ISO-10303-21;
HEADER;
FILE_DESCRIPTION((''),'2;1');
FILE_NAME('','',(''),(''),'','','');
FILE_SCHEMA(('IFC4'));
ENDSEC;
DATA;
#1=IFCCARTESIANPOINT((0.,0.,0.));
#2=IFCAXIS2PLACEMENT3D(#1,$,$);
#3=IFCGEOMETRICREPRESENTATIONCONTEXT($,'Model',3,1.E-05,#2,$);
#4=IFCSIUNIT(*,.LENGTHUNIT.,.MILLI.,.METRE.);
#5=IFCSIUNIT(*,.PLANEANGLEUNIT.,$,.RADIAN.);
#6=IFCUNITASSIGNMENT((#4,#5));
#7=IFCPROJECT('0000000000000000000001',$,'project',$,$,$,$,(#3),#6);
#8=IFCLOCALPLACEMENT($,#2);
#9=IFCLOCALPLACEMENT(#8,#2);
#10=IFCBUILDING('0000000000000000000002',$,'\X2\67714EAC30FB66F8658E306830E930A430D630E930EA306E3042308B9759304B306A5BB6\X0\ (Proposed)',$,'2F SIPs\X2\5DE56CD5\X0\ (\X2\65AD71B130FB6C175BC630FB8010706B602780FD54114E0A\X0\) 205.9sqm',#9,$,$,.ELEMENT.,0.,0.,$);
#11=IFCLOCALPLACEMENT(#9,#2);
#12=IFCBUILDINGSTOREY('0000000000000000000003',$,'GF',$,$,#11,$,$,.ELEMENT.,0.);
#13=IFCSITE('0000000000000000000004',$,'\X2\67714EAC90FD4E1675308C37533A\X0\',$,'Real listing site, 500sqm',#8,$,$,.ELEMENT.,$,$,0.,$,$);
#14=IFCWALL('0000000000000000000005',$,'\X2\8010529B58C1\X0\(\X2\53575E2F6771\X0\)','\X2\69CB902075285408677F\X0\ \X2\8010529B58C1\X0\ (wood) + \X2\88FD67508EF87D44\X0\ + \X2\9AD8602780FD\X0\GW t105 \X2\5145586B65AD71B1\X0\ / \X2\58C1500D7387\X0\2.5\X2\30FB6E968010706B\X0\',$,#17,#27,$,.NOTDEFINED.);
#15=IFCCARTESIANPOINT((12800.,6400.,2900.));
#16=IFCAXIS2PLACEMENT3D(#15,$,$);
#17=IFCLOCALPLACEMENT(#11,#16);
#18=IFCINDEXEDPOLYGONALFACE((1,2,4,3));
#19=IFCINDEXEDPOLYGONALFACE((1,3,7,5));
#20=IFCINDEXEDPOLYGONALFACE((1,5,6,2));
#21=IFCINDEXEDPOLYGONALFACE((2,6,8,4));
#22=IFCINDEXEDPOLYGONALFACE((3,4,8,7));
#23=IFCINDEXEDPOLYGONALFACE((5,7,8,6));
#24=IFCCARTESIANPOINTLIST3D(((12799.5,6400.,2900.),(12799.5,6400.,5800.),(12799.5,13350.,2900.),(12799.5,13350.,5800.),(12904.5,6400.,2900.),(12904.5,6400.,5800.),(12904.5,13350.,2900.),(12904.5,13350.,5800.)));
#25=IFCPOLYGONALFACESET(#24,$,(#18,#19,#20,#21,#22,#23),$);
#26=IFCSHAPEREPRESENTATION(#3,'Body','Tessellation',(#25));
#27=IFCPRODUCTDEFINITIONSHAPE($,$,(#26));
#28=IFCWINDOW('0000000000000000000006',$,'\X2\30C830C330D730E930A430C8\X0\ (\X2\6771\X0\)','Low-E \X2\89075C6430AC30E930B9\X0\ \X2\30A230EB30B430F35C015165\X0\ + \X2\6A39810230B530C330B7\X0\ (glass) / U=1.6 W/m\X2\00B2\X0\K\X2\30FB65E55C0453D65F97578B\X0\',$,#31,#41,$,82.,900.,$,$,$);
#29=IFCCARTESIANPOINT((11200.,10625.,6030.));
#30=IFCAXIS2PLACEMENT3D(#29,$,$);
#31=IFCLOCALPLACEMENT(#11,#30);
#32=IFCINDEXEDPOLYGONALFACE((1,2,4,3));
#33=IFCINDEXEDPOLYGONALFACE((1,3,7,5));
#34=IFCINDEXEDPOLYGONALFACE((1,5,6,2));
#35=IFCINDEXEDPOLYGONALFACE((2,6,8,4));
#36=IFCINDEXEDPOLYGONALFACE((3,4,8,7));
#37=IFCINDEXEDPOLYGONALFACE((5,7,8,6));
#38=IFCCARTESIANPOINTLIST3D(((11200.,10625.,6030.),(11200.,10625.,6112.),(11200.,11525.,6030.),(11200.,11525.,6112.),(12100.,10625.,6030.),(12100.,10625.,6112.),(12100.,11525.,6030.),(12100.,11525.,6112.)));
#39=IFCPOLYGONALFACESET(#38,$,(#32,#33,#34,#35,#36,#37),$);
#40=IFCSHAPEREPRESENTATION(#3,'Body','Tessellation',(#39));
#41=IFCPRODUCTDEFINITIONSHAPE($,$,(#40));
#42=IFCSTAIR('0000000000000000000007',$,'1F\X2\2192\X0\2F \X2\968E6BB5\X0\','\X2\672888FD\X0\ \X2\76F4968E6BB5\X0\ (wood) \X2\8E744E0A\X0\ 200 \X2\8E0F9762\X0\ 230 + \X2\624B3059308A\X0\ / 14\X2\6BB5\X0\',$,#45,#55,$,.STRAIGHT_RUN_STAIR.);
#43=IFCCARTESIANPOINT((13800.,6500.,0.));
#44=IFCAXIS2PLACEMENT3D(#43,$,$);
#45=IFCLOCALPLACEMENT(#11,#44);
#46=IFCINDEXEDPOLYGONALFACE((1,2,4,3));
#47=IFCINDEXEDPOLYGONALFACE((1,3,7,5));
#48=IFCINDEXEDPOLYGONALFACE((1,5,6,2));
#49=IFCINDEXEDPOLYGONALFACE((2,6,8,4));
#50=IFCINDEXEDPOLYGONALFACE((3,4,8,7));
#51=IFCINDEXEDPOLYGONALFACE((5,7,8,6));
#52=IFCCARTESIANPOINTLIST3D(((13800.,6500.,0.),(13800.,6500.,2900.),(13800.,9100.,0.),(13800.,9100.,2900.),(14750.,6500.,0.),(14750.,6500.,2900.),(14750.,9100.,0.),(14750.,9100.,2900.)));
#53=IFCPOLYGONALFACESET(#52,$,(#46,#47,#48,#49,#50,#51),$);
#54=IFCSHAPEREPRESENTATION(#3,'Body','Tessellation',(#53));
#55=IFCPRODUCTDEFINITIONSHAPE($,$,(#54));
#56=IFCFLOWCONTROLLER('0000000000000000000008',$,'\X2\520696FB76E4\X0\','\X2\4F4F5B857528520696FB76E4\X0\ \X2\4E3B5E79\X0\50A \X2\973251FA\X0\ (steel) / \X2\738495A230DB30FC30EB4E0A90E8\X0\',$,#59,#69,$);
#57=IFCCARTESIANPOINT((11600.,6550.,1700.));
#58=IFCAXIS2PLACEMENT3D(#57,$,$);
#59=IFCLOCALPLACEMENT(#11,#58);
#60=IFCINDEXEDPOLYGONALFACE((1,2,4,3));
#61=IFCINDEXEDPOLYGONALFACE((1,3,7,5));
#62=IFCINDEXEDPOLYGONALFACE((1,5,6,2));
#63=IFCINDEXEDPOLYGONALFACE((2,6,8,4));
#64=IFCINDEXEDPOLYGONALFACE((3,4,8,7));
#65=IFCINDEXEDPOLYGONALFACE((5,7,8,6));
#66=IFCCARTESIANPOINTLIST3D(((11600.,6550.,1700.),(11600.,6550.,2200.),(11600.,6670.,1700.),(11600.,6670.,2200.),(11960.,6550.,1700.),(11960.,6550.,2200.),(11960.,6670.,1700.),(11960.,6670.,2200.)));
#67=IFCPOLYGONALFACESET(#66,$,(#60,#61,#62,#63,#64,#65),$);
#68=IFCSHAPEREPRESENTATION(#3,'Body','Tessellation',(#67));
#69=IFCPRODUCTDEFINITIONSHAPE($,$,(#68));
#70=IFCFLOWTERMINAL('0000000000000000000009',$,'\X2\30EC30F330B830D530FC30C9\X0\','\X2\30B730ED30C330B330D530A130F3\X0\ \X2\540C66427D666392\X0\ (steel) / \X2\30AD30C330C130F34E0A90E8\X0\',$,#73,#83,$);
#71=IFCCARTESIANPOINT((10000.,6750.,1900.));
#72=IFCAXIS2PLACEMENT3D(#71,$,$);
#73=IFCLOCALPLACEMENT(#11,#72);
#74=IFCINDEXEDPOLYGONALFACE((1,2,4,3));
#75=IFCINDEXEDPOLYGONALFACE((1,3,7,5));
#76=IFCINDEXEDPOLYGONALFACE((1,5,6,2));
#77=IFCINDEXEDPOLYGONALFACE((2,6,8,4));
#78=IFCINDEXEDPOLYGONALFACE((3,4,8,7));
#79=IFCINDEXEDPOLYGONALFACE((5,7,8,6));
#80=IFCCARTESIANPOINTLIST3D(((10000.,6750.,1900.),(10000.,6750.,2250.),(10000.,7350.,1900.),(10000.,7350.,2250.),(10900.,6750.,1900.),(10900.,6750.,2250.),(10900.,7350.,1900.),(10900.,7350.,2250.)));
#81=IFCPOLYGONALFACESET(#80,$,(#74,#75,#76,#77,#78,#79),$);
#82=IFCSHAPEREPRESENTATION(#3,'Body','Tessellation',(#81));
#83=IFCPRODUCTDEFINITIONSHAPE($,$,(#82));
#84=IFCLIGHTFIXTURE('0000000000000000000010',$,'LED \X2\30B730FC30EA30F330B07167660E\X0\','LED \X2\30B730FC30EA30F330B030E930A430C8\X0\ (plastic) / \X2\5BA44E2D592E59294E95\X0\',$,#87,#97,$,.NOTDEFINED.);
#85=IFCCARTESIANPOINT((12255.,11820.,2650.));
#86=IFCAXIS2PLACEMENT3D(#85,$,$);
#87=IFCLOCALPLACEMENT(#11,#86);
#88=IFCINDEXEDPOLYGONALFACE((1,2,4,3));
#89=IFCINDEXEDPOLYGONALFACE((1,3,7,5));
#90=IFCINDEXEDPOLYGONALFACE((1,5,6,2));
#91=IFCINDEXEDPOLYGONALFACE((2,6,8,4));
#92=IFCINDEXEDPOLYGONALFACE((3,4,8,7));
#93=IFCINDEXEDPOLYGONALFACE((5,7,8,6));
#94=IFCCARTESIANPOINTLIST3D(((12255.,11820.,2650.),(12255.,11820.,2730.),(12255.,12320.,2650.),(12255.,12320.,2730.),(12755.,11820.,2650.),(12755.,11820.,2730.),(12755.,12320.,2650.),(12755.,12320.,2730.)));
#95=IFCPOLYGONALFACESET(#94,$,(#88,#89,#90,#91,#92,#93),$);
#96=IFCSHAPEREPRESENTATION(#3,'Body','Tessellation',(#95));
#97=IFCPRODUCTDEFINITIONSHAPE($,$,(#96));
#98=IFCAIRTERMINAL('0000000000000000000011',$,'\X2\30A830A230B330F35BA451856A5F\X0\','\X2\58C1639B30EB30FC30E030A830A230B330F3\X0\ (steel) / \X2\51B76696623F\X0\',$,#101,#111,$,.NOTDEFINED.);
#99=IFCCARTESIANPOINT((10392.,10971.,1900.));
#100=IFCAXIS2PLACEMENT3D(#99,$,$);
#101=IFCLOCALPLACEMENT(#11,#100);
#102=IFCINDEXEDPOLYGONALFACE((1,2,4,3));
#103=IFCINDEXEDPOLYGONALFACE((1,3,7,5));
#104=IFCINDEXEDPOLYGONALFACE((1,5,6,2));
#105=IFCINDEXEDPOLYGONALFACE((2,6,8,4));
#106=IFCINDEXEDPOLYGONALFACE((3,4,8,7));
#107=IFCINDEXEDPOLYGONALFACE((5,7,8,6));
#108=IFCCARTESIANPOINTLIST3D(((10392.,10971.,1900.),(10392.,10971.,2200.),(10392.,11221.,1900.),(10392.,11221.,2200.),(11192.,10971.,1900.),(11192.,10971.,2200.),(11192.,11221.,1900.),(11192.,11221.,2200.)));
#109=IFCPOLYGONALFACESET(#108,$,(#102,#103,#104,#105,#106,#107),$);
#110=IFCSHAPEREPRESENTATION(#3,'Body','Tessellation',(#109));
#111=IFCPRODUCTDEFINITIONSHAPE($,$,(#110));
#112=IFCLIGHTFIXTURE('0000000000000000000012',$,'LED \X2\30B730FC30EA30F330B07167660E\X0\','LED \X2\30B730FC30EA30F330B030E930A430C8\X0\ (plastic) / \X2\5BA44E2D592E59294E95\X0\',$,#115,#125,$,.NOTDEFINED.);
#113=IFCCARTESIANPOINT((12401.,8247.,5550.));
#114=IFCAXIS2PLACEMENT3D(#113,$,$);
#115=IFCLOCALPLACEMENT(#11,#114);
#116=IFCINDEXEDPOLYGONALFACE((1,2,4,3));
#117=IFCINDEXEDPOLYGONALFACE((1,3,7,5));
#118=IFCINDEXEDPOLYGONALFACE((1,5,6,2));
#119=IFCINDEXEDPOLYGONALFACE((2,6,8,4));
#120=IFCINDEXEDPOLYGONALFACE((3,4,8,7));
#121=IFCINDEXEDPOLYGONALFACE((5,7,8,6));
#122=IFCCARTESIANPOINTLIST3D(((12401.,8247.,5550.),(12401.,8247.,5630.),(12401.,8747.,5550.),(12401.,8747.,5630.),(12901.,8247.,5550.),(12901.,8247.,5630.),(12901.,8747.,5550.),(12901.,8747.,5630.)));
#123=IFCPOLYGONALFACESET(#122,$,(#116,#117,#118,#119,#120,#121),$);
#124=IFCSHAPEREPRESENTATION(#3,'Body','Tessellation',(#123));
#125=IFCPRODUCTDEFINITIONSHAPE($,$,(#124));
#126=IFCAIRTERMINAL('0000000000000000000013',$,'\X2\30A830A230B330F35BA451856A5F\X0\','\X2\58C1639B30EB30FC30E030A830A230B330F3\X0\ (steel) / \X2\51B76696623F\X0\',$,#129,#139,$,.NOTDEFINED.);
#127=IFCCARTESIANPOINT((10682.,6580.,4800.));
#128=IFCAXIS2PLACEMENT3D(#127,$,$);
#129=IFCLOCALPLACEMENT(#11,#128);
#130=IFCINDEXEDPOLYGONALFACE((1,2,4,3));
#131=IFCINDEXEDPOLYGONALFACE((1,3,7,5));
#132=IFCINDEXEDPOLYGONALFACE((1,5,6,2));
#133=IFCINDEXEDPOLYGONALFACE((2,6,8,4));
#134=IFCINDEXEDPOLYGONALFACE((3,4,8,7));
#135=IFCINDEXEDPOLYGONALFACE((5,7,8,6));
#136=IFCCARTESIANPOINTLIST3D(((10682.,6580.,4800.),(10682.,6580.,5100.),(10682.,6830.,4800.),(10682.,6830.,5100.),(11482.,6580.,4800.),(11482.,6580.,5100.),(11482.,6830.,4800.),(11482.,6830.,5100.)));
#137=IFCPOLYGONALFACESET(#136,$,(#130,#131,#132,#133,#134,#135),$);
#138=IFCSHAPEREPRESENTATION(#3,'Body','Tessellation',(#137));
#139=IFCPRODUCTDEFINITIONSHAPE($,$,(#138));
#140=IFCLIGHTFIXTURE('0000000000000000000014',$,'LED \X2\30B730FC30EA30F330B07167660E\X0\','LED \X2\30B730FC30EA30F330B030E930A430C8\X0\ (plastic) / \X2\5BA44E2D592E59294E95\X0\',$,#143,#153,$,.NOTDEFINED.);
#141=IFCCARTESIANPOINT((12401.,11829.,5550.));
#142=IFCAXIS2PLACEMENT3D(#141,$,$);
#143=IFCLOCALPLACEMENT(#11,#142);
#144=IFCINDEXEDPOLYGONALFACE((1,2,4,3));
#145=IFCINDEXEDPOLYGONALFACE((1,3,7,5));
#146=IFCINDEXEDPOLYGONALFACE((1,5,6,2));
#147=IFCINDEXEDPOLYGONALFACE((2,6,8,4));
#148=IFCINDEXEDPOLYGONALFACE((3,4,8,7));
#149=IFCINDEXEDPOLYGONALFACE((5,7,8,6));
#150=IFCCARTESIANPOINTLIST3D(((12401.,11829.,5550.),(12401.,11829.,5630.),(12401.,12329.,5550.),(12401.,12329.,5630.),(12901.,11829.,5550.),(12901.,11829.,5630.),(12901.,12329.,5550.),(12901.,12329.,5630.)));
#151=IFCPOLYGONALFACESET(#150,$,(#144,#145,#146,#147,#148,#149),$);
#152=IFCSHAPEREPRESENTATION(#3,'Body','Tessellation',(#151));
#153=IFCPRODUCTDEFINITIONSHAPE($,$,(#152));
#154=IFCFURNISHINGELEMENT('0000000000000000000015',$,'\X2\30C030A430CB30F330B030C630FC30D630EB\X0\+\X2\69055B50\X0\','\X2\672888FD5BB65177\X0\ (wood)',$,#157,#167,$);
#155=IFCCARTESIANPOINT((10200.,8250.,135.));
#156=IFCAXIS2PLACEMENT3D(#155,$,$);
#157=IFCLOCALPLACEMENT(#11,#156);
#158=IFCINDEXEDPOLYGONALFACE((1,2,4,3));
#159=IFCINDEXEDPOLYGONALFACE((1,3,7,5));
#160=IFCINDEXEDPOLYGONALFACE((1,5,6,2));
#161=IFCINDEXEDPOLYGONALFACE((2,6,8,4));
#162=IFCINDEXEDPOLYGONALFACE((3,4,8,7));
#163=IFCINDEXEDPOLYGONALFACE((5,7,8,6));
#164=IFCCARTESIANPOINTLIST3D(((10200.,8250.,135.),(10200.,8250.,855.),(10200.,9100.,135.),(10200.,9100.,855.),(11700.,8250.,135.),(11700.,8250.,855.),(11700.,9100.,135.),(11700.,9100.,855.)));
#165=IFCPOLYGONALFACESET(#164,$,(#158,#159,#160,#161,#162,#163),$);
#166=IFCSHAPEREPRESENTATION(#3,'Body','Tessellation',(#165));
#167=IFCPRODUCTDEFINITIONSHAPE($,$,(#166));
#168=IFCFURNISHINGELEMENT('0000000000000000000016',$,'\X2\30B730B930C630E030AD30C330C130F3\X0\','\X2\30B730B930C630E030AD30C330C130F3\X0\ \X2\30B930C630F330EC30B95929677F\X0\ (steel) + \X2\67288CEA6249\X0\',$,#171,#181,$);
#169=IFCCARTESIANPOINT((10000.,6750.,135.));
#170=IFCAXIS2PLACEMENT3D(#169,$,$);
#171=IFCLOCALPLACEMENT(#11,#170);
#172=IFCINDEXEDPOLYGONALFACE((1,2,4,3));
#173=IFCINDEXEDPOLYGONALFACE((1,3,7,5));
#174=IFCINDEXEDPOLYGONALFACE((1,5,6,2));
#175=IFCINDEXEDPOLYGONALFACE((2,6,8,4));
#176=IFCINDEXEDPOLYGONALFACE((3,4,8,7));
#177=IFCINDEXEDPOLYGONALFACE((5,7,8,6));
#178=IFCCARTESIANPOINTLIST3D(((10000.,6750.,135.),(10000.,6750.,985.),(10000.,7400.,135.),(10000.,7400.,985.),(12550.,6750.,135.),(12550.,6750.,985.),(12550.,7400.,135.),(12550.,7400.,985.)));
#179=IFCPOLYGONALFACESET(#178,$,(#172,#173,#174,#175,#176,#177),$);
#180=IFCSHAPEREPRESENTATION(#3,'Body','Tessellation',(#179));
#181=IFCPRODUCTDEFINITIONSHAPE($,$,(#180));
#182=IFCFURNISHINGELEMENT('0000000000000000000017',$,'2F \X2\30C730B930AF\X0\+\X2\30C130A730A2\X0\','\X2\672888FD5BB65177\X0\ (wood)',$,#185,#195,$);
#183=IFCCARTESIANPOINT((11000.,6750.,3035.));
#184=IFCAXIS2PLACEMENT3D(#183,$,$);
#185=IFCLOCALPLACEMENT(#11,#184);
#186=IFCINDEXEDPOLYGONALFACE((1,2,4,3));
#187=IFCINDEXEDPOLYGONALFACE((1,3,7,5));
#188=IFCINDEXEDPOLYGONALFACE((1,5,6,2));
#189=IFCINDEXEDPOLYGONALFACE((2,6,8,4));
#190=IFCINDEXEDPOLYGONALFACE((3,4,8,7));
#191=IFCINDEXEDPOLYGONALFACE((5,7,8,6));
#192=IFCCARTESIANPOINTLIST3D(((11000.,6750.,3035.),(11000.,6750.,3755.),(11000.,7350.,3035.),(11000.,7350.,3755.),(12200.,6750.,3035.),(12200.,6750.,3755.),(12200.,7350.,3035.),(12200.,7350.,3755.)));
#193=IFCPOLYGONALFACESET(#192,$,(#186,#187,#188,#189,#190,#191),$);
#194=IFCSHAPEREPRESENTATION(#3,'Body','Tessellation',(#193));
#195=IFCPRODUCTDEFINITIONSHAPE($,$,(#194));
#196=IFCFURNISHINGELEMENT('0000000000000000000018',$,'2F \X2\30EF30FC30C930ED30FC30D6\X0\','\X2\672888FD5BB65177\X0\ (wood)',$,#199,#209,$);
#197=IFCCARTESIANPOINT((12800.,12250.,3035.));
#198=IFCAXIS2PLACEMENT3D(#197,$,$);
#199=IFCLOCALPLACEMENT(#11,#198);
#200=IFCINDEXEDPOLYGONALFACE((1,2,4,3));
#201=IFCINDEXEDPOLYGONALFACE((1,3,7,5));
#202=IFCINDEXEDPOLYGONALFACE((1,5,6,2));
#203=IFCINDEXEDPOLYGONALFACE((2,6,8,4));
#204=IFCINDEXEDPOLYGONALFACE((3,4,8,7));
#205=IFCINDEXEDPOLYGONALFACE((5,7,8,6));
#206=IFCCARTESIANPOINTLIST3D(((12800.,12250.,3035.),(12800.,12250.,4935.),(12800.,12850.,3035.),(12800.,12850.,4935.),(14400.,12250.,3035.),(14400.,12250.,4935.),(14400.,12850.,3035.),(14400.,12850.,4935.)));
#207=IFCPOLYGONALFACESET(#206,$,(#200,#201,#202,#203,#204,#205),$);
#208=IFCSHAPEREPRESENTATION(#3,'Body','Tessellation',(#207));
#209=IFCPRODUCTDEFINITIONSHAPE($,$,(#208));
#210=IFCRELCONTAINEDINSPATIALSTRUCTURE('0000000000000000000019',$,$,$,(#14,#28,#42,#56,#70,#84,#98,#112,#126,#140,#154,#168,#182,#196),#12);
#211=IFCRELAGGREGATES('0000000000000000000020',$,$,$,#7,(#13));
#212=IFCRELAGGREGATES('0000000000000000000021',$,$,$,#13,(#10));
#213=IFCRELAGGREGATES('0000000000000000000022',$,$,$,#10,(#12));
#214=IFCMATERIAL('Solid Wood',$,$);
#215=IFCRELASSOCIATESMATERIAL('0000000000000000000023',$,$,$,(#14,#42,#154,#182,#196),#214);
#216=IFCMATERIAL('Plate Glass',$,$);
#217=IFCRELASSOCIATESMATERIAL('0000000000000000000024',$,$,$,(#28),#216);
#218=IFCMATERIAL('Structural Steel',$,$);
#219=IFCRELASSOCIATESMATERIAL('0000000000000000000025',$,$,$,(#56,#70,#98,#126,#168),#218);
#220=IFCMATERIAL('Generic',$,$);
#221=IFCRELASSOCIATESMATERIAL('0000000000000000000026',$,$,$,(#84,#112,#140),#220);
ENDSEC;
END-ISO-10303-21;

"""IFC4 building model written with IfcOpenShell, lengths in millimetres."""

from ifc_helpers import new_model, si_unit, frame, frame_2d, origin, place, context, project, spatial, rectangle, extrude, material, element, save


model = new_model("IFC4")

# Units and contexts
model_context = context("Model", 3, precision=1e-05, world=origin())
ifc_project = project(units=[si_unit("LENGTHUNIT", "METRE", prefix="MILLI"), si_unit("PLANEANGLEUNIT", "RADIAN")], contexts=[model_context])

# Site, building, storey
site_placement = place(None, origin())
site = spatial("IfcSite", under=ifc_project, at=site_placement, Name="東京都世田谷区", ObjectType="Real listing site, 500sqm", CompositionType="ELEMENT", RefElevation=0.0)
building_placement = place(site_placement, origin())
building = spatial("IfcBuilding", under=site, at=building_placement, Name="東京・書斎とライブラリのある静かな家 (Proposed)", ObjectType="2F SIPs工法 (断熱・気密・耐火性能向上) 205.9sqm", CompositionType="ELEMENT", ElevationOfRefHeight=0.0, ElevationOfTerrain=0.0)
storey_placement = place(building_placement, origin())
storey = spatial("IfcBuildingStorey", under=building, at=storey_placement, Name="GF", CompositionType="ELEMENT", Elevation=0.0)

# Shared definitions
ifc_material_1 = material(Name="Solid Wood")

# Wall
wall_1_placement = place(storey_placement, frame((12800.0, 6400.0, 2900.0)))
element("IfcWall", 1, at=wall_1_placement, inside=storey, material=ifc_material_1, Name="耐力壁(南帯東)", Description="構造用合板 耐力壁 (wood) + 製材軸組 + 高性能GW t105 充填断熱 / 壁倍率2.5・準耐火", PredefinedType="NOTDEFINED", context=model_context, shape_type="SweptSolid", body=[
    extrude(rectangle(XDim=105.0, YDim=6950.0, at=frame_2d((52.0, 3475.0))), frame((12800.0, 6400.0, 2900.0)), (0.0, 0.0, 1.0), 2900.0),
])

# Window
ifc_material_2 = material(Name="Plate Glass")
window_placement = place(storey_placement, frame((11200.0, 10625.0, 6030.0)))
element("IfcWindow", 2, at=window_placement, inside=storey, material=ifc_material_2, Name="トップライト (東)", Description="Low-E 複層ガラス アルゴン封入 + 樹脂サッシ (glass) / U=1.6 W/m²K・日射取得型", OverallHeight=82.0, OverallWidth=900.0, context=model_context, shape_type="SweptSolid", body=[
    extrude(rectangle(XDim=900.0, YDim=900.0, at=frame_2d((450.0, 450.0))), frame((11200.0, 10625.0, 6030.0)), (0.0, 0.0, 1.0), 82.0),
])

# Stair
stair_placement = place(storey_placement, frame((13800.0, 6500.0, 0.0)))
element("IfcStair", 3, at=stair_placement, inside=storey, material=ifc_material_1, Name="1F→2F 階段", Description="木製 直階段 (wood) 蹴上 200 踏面 230 + 手すり / 14段", PredefinedType="STRAIGHT_RUN_STAIR", context=model_context, shape_type="SweptSolid", body=[
    extrude(rectangle(XDim=950.0, YDim=2600.0, at=frame_2d((475.0, 1300.0))), frame((13800.0, 6500.0, 0.0)), (0.0, 0.0, 1.0), 2900.0),
])

# Flow controller
ifc_material_3 = material(Name="Structural Steel")
flow_controller_placement = place(storey_placement, frame((11600.0, 6550.0, 1700.0)))
element("IfcFlowController", 4, at=flow_controller_placement, inside=storey, material=ifc_material_3, Name="分電盤", Description="住宅用分電盤 主幹50A 露出 (steel) / 玄関ホール上部", context=model_context, shape_type="SweptSolid", body=[
    extrude(rectangle(XDim=360.0, YDim=120.0, at=frame_2d((180.0, 60.0))), frame((11600.0, 6550.0, 1700.0)), (0.0, 0.0, 1.0), 500.0),
])

# Flow terminal
flow_terminal_placement = place(storey_placement, frame((10000.0, 6750.0, 1900.0)))
element("IfcFlowTerminal", 5, at=flow_terminal_placement, inside=storey, material=ifc_material_3, Name="レンジフード", Description="シロッコファン 同時給排 (steel) / キッチン上部", context=model_context, shape_type="SweptSolid", body=[
    extrude(rectangle(XDim=900.0, YDim=600.0, at=frame_2d((450.0, 300.0))), frame((10000.0, 6750.0, 1900.0)), (0.0, 0.0, 1.0), 350.0),
])

# Light fixture
ifc_material_4 = material(Name="Generic")
light_fixture_1_placement = place(storey_placement, frame((12255.0, 11820.0, 2650.0)))
element("IfcLightFixture", 6, at=light_fixture_1_placement, inside=storey, material=ifc_material_4, Name="LED シーリング照明", Description="LED シーリングライト (plastic) / 室中央天井", PredefinedType="NOTDEFINED", context=model_context, shape_type="SweptSolid", body=[
    extrude(rectangle(XDim=500.0, YDim=500.0, at=frame_2d((250.0, 250.0))), frame((12255.0, 11820.0, 2650.0)), (0.0, 0.0, 1.0), 80.0),
])

# Air terminal
air_terminal_1_placement = place(storey_placement, frame((10392.0, 10971.0, 1900.0)))
element("IfcAirTerminal", 7, at=air_terminal_1_placement, inside=storey, material=ifc_material_3, Name="エアコン室内機", Description="壁掛ルームエアコン (steel) / 冷暖房", PredefinedType="NOTDEFINED", context=model_context, shape_type="SweptSolid", body=[
    extrude(rectangle(XDim=800.0, YDim=250.0, at=frame_2d((400.0, 125.0))), frame((10392.0, 10971.0, 1900.0)), (0.0, 0.0, 1.0), 300.0),
])

# Light fixture
light_fixture_2_placement = place(storey_placement, frame((12401.0, 8247.0, 5550.0)))
element("IfcLightFixture", 8, at=light_fixture_2_placement, inside=storey, material=ifc_material_4, Name="LED シーリング照明", Description="LED シーリングライト (plastic) / 室中央天井", PredefinedType="NOTDEFINED", context=model_context, shape_type="SweptSolid", body=[
    extrude(rectangle(XDim=500.0, YDim=500.0, at=frame_2d((250.0, 250.0))), frame((12401.0, 8247.0, 5550.0)), (0.0, 0.0, 1.0), 80.0),
])

# Air terminal
air_terminal_2_placement = place(storey_placement, frame((10682.0, 6580.0, 4800.0)))
element("IfcAirTerminal", 9, at=air_terminal_2_placement, inside=storey, material=ifc_material_3, Name="エアコン室内機", Description="壁掛ルームエアコン (steel) / 冷暖房", PredefinedType="NOTDEFINED", context=model_context, shape_type="SweptSolid", body=[
    extrude(rectangle(XDim=800.0, YDim=250.0, at=frame_2d((400.0, 125.0))), frame((10682.0, 6580.0, 4800.0)), (0.0, 0.0, 1.0), 300.0),
])

# Light fixture
light_fixture_3_placement = place(storey_placement, frame((12401.0, 11829.0, 5550.0)))
element("IfcLightFixture", 10, at=light_fixture_3_placement, inside=storey, material=ifc_material_4, Name="LED シーリング照明", Description="LED シーリングライト (plastic) / 室中央天井", PredefinedType="NOTDEFINED", context=model_context, shape_type="SweptSolid", body=[
    extrude(rectangle(XDim=500.0, YDim=500.0, at=frame_2d((250.0, 250.0))), frame((12401.0, 11829.0, 5550.0)), (0.0, 0.0, 1.0), 80.0),
])

# Furnishing elements
furnishing_1_placement = place(storey_placement, frame((10200.0, 8250.0, 135.0)))
element("IfcFurnishingElement", 11, at=furnishing_1_placement, inside=storey, material=ifc_material_1, Name="ダイニングテーブル+椅子", Description="木製家具 (wood)", context=model_context, shape_type="SweptSolid", body=[
    extrude(rectangle(XDim=1500.0, YDim=850.0, at=frame_2d((750.0, 425.0))), frame((10200.0, 8250.0, 135.0)), (0.0, 0.0, 1.0), 720.0),
])
furnishing_2_placement = place(storey_placement, frame((10000.0, 6750.0, 135.0)))
element("IfcFurnishingElement", 12, at=furnishing_2_placement, inside=storey, material=ifc_material_3, Name="システムキッチン", Description="システムキッチン ステンレス天板 (steel) + 木質扉", context=model_context, shape_type="SweptSolid", body=[
    extrude(rectangle(XDim=2550.0, YDim=650.0, at=frame_2d((1275.0, 325.0))), frame((10000.0, 6750.0, 135.0)), (0.0, 0.0, 1.0), 850.0),
])
furnishing_3_placement = place(storey_placement, frame((11000.0, 6750.0, 3035.0)))
element("IfcFurnishingElement", 13, at=furnishing_3_placement, inside=storey, material=ifc_material_1, Name="2F デスク+チェア", Description="木製家具 (wood)", context=model_context, shape_type="SweptSolid", body=[
    extrude(rectangle(XDim=1200.0, YDim=600.0, at=frame_2d((600.0, 300.0))), frame((11000.0, 6750.0, 3035.0)), (0.0, 0.0, 1.0), 720.0),
])
furnishing_4_placement = place(storey_placement, frame((12800.0, 12250.0, 3035.0)))
element("IfcFurnishingElement", 14, at=furnishing_4_placement, inside=storey, material=ifc_material_1, Name="2F ワードローブ", Description="木製家具 (wood)", context=model_context, shape_type="SweptSolid", body=[
    extrude(rectangle(XDim=1600.0, YDim=600.0, at=frame_2d((800.0, 300.0))), frame((12800.0, 12250.0, 3035.0)), (0.0, 0.0, 1.0), 1900.0),
])

save(model, "model.ifc")
